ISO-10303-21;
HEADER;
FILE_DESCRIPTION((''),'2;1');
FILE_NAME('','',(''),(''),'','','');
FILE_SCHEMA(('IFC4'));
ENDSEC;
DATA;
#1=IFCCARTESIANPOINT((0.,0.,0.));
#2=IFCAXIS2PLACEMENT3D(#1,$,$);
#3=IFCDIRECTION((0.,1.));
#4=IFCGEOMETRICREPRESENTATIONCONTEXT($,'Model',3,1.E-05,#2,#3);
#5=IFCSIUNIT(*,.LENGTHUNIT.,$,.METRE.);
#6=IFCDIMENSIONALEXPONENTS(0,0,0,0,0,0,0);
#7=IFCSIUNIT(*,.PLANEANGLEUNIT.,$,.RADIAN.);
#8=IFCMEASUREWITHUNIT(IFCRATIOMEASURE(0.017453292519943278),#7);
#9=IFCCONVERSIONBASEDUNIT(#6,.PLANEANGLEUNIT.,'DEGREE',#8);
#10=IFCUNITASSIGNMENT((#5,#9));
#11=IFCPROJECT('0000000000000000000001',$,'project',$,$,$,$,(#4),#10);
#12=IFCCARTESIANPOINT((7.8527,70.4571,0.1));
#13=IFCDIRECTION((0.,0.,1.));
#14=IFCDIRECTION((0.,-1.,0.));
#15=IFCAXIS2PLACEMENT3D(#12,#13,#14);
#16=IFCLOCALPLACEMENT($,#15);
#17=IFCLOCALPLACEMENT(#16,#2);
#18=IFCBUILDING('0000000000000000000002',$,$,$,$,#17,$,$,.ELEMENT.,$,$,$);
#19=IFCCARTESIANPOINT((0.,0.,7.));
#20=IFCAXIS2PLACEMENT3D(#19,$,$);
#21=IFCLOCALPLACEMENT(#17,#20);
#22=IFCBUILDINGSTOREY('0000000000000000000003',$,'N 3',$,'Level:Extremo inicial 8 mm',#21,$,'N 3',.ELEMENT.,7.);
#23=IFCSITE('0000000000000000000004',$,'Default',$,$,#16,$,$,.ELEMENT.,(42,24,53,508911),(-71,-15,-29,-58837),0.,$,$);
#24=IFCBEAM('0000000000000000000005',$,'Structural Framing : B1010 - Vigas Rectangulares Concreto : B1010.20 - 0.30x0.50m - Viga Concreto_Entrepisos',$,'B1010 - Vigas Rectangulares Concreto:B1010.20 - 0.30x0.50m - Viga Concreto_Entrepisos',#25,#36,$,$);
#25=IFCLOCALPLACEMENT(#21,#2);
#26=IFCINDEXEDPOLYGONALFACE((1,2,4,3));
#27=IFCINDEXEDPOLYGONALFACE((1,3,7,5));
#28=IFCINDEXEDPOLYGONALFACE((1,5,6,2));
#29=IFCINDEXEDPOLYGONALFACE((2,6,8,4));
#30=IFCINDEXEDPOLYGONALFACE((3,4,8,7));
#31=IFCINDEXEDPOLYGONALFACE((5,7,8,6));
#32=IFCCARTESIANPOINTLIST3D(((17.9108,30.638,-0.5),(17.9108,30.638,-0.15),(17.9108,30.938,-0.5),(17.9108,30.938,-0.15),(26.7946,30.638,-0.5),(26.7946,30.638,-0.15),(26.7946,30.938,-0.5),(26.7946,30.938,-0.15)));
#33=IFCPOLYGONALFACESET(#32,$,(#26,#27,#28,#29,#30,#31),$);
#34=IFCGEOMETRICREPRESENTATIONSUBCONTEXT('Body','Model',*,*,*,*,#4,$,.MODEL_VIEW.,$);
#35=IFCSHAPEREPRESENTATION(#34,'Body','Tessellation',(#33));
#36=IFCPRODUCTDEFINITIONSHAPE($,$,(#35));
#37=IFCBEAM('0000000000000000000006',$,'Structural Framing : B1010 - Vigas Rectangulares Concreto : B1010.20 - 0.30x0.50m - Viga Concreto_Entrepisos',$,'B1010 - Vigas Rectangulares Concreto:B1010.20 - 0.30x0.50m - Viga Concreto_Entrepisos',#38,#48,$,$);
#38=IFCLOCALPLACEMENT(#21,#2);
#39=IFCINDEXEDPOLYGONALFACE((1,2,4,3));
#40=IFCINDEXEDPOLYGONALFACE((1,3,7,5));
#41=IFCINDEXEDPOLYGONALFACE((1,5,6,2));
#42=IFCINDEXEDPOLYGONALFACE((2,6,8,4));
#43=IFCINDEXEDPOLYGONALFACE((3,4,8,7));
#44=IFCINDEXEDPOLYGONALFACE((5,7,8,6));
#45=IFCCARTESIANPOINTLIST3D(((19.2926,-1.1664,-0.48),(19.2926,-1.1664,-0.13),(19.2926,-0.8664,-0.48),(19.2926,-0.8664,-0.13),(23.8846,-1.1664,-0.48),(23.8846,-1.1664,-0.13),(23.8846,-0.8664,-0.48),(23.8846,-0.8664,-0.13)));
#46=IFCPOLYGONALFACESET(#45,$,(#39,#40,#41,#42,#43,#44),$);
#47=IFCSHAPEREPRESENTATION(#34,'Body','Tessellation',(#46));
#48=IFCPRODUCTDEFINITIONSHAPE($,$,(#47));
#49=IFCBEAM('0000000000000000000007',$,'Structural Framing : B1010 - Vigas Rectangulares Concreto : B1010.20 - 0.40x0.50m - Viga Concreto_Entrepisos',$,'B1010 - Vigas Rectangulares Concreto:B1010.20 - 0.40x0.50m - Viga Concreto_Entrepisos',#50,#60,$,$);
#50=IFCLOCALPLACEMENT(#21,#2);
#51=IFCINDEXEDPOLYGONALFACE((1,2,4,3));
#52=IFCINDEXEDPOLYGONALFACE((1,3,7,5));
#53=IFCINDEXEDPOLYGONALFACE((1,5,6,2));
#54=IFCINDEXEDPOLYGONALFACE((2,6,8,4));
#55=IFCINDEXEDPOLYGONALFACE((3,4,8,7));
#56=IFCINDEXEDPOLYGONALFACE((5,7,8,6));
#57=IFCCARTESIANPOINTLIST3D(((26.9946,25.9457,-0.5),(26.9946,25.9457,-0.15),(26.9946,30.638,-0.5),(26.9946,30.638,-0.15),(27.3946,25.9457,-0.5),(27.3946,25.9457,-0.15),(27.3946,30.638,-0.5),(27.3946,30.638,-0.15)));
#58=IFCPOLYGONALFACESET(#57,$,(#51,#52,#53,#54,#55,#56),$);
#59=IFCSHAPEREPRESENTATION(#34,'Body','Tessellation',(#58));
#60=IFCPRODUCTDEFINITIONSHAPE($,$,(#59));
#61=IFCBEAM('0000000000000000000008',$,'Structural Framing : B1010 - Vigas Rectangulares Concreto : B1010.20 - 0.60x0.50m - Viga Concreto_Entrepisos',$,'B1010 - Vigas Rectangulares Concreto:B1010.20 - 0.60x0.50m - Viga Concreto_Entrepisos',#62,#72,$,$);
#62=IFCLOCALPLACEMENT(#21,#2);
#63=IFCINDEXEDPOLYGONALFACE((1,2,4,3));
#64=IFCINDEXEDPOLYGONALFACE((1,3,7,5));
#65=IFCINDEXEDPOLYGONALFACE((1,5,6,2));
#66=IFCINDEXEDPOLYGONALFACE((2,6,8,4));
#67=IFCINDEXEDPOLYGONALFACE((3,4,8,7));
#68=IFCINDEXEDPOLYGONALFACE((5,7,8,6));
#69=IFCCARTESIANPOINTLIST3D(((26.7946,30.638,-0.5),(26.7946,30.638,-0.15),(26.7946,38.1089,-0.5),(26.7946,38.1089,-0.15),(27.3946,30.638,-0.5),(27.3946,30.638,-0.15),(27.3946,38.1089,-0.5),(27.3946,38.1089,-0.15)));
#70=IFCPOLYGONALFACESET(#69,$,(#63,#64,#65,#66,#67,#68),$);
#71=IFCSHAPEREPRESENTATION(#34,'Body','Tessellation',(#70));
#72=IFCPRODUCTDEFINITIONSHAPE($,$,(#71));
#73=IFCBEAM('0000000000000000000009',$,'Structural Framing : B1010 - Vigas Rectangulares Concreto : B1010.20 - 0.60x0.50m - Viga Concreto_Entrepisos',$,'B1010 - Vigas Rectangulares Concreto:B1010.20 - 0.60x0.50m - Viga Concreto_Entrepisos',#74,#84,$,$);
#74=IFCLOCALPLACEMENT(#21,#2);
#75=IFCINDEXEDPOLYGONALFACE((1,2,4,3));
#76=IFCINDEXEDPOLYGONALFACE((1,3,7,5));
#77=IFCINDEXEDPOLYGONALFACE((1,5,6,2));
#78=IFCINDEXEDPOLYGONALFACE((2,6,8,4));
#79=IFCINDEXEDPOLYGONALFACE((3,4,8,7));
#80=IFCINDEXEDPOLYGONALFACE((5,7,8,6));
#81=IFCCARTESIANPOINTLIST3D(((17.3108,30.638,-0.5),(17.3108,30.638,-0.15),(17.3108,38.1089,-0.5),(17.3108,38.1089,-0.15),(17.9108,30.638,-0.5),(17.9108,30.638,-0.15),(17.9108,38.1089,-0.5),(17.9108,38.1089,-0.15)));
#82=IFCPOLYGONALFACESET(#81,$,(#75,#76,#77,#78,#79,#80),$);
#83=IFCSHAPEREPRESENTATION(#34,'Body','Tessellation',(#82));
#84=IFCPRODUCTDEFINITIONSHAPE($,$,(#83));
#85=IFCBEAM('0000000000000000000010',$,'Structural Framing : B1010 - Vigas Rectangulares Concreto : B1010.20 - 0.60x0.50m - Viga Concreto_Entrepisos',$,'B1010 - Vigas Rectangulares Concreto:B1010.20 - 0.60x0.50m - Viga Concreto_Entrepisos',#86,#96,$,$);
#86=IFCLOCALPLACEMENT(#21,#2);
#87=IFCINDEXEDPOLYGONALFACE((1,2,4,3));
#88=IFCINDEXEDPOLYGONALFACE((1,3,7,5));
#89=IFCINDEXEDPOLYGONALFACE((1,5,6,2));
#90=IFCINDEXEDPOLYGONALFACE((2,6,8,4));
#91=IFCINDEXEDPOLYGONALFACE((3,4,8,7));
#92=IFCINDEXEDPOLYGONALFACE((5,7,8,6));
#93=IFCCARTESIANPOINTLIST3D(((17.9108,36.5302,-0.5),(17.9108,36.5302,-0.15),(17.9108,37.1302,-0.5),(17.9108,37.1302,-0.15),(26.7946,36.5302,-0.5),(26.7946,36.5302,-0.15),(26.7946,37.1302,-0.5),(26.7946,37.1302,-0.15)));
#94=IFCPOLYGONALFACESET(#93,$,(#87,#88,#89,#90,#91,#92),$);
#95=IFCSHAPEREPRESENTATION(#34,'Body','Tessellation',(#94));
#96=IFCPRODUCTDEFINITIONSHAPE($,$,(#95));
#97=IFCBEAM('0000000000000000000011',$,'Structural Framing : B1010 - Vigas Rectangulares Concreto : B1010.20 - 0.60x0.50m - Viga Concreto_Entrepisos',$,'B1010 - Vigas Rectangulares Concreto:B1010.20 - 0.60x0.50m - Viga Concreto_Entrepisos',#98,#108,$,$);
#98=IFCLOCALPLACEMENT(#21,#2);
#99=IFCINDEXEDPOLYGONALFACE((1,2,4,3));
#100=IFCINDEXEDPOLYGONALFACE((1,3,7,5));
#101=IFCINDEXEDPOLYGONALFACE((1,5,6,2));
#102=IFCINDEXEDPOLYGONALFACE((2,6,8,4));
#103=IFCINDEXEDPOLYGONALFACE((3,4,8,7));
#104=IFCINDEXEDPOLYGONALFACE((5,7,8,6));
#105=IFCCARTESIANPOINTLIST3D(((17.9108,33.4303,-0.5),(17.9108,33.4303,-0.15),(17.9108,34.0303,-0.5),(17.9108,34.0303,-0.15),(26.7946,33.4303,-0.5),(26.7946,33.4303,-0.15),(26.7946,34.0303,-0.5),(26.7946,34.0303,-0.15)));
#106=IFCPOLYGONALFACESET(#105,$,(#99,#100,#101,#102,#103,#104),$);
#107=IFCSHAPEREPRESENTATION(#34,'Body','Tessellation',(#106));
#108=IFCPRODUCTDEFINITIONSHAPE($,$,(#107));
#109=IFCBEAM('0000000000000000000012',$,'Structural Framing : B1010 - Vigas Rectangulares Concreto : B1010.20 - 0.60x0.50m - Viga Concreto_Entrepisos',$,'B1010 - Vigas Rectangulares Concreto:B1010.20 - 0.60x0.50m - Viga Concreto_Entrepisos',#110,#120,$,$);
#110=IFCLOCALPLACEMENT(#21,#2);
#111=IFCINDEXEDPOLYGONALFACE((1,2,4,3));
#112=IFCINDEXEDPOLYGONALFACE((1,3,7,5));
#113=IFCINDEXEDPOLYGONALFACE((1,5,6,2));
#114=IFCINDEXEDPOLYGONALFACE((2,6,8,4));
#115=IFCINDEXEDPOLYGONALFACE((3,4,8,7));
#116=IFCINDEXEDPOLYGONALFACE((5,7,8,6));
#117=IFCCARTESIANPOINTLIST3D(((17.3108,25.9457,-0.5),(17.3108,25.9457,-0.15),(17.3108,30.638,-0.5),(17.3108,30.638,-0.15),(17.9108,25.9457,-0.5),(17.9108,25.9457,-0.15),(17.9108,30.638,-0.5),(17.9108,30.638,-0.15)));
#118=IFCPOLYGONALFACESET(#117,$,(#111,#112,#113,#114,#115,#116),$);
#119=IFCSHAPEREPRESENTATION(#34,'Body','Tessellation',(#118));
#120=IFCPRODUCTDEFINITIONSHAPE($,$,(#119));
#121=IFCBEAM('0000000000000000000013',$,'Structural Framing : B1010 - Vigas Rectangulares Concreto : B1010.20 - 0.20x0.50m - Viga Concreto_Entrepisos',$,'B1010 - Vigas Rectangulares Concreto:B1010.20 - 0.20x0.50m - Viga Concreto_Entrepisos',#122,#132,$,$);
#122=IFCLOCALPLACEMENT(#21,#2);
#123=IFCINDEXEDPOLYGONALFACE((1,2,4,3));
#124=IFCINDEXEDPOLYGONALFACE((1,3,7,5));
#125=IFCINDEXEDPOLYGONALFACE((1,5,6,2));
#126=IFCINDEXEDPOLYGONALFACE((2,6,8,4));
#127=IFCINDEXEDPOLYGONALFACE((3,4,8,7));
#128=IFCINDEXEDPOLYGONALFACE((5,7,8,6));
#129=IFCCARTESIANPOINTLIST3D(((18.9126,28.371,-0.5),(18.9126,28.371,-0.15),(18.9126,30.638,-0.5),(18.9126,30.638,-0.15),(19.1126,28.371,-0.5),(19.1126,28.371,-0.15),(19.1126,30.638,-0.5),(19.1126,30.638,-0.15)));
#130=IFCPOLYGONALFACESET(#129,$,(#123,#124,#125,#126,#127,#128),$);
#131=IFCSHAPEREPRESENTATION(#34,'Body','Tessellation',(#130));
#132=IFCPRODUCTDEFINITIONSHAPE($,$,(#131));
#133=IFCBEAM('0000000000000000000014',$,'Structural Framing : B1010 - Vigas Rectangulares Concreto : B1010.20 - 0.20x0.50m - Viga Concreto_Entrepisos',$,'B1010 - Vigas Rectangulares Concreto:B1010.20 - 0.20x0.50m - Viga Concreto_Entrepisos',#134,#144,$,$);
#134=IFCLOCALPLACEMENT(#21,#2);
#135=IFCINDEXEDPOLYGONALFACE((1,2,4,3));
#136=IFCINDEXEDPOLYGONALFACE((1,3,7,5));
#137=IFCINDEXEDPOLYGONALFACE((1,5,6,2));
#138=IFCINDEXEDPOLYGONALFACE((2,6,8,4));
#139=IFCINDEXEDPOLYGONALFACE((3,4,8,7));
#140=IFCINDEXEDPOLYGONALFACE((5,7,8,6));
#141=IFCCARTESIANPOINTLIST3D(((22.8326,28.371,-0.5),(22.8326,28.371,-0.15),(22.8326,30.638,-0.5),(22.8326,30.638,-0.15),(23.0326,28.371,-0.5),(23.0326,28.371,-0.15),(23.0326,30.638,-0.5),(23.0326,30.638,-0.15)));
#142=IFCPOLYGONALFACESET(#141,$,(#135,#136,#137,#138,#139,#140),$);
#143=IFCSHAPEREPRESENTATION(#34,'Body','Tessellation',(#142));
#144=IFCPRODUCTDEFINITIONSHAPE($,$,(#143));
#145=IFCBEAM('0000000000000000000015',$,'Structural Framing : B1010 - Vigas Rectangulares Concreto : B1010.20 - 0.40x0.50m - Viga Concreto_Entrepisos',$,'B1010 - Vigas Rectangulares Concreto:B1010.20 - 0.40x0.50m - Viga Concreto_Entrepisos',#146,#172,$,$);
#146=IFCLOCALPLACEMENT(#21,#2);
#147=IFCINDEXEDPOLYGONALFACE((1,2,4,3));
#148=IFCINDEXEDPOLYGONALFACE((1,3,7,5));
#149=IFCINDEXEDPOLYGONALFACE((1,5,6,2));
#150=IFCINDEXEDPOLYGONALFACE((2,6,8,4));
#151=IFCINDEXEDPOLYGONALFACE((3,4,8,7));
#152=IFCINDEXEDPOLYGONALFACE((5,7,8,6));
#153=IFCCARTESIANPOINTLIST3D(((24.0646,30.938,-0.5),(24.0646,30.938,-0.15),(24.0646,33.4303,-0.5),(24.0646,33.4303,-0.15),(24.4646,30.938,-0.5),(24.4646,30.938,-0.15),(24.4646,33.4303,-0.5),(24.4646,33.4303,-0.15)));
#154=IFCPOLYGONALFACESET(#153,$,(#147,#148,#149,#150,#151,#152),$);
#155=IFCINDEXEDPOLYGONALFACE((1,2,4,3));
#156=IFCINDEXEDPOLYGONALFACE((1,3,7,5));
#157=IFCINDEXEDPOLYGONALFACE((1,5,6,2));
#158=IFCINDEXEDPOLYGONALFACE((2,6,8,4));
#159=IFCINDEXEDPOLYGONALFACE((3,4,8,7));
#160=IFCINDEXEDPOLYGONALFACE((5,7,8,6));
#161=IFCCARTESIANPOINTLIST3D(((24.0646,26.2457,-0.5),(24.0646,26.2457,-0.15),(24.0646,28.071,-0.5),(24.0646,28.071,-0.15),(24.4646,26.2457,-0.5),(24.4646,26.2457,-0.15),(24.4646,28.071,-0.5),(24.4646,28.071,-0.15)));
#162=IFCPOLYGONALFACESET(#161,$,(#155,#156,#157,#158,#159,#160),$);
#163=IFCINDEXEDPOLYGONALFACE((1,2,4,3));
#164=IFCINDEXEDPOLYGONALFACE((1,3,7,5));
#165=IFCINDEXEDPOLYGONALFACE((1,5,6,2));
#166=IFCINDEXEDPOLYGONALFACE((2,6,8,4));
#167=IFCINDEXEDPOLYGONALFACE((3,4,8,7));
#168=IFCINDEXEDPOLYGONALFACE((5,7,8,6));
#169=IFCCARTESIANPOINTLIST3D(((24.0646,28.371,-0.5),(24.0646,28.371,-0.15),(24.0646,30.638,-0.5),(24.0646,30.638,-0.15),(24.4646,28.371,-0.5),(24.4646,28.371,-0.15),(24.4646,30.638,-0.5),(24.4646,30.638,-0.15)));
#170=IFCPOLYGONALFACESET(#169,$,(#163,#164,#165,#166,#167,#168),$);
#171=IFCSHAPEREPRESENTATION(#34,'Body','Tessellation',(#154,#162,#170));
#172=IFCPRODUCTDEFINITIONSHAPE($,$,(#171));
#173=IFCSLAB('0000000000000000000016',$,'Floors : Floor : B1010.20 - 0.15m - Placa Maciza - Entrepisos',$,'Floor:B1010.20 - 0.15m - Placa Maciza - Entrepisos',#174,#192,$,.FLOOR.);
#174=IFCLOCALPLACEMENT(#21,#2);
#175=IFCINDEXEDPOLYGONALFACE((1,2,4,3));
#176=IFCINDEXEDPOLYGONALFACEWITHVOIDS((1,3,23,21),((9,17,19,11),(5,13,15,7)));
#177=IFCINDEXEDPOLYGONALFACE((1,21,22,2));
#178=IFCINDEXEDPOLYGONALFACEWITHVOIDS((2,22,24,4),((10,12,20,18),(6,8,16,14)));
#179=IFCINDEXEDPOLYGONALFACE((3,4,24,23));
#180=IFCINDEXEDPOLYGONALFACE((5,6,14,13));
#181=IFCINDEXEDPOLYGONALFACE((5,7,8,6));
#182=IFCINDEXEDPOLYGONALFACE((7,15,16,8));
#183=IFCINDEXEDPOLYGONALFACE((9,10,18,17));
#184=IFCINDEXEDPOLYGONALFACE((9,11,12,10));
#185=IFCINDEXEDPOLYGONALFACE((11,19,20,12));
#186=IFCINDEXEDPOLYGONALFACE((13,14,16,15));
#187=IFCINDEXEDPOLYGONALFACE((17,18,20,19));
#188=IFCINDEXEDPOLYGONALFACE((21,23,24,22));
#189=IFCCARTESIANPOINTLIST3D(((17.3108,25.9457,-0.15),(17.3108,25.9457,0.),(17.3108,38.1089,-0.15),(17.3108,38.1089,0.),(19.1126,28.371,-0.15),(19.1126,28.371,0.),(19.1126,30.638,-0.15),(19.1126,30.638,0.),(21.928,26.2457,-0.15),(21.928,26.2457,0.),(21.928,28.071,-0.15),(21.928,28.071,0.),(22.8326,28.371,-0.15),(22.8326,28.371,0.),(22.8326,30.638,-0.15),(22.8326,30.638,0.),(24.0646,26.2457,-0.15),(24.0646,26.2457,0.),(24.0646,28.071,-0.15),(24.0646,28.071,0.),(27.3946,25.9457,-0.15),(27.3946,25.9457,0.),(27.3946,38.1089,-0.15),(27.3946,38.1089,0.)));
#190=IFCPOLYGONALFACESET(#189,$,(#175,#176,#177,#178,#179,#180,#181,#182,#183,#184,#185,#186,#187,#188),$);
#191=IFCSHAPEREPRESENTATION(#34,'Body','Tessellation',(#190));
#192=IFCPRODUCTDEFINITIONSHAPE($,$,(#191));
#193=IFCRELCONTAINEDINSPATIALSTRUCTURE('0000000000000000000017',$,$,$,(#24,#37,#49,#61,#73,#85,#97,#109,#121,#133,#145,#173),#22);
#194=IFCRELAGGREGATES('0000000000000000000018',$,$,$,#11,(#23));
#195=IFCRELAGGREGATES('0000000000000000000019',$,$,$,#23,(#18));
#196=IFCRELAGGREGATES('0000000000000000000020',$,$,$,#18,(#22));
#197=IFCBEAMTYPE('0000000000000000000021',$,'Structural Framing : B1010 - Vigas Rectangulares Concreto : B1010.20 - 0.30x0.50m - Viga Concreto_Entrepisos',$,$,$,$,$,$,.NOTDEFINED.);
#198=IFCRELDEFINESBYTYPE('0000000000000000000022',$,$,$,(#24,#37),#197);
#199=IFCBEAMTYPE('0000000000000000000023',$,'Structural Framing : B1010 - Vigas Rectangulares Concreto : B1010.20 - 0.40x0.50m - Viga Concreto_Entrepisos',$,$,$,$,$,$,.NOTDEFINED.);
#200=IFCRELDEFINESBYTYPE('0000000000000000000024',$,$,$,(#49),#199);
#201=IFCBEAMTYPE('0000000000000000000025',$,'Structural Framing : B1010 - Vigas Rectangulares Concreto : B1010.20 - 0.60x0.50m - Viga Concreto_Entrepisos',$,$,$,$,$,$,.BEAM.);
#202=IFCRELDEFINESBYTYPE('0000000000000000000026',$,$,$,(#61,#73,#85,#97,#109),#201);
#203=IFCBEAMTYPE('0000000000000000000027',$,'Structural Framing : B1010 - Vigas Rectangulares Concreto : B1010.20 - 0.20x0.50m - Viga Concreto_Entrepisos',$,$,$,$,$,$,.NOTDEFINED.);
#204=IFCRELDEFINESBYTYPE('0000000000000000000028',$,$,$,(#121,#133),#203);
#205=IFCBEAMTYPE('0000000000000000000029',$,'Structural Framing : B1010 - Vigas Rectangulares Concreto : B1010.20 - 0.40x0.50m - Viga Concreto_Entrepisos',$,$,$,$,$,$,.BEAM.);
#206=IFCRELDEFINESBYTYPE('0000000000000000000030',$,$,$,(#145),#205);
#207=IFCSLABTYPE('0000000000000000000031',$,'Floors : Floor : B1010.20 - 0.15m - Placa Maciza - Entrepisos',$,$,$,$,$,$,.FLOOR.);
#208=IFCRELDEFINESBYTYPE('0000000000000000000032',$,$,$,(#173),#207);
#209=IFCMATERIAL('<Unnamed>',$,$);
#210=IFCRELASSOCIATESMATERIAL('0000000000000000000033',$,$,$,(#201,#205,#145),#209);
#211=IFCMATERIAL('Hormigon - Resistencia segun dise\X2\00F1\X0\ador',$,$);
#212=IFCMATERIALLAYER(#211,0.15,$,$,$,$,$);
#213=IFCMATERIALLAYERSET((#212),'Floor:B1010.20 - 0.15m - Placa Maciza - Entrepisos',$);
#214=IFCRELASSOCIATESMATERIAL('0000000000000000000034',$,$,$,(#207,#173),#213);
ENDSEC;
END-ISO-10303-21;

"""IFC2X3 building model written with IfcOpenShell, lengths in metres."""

from ifc_helpers import new_model, entity, si_unit, converted_unit, direction, frame, frame_2d, origin, origin_2d_with_axis, place, context, subcontext, project, spatial, rectangle, extrude, source, transform, mapped, material, layer, layer_set, layer_usage, type_object, type_shapes, element, save


model = new_model("IFC2X3")

# Units and contexts
model_context = context("Model", 3, precision=1e-05, world=origin(), true_north=direction((0.0, 1.0)))
body_context = subcontext(model_context, "Body", "Model", "MODEL_VIEW")
ifc_project = project(units=[si_unit("LENGTHUNIT", "METRE"), converted_unit("PLANEANGLEUNIT", "DEGREE", entity("IfcRatioMeasure", 0.017453292519943278), si_unit("PLANEANGLEUNIT", "RADIAN"), dimensions=[0, 0, 0, 0, 0, 0, 0])], contexts=[model_context])

# Site, building, storey
site_placement = place(None, frame((7.8527, 70.4571, 0.1), z_axis=(0.0, 0.0, 1.0), x_axis=(0.0, -1.0, 0.0)))
site = spatial("IfcSite", under=ifc_project, at=site_placement, Name="Default", CompositionType="ELEMENT", RefLatitude=(42, 24, 53, 508911), RefLongitude=(-71, -15, -29, -58837), RefElevation=0.0)
building_placement = place(site_placement, origin())
building = spatial("IfcBuilding", under=site, at=building_placement, CompositionType="ELEMENT")
storey_placement = place(building_placement, frame((0.0, 0.0, 7.0)))
storey = spatial("IfcBuildingStorey", under=building, at=storey_placement, Name="N 3", ObjectType="Level:Extremo inicial 8 mm", LongName="N 3", CompositionType="ELEMENT", Elevation=7.0)

# Beams
beam_type_1 = type_object("IfcBeamType", Name="Structural Framing : B1010 - Vigas Rectangulares Concreto : B1010.20 - 0.30x0.50m - Viga Concreto_Entrepisos", PredefinedType="NOTDEFINED")
beam_1_placement = place(storey_placement, frame((17.6108, 30.788, 0.0)))
element("IfcBeam", 1, at=beam_1_placement, inside=storey, type_object=beam_type_1, Name="Structural Framing : B1010 - Vigas Rectangulares Concreto : B1010.20 - 0.30x0.50m - Viga Concreto_Entrepisos", ObjectType="B1010 - Vigas Rectangulares Concreto:B1010.20 - 0.30x0.50m - Viga Concreto_Entrepisos", context=body_context, shape_type="SweptSolid", body=[
    extrude(rectangle(XDim=0.35, YDim=0.3, at=frame_2d((0.0, 0.0), x_axis=(1.0, 0.0))), frame((0.3, 0.0, -0.325), z_axis=(1.0, 0.0, 0.0), x_axis=(0.0, 0.0, -1.0)), (0.0, 0.0, 1.0), 8.8838),
])
beam_2_placement = place(storey_placement, frame((19.1426, -1.0164, 0.0)))
element("IfcBeam", 2, at=beam_2_placement, inside=storey, type_object=beam_type_1, Name="Structural Framing : B1010 - Vigas Rectangulares Concreto : B1010.20 - 0.30x0.50m - Viga Concreto_Entrepisos", ObjectType="B1010 - Vigas Rectangulares Concreto:B1010.20 - 0.30x0.50m - Viga Concreto_Entrepisos", context=body_context, shape_type="SweptSolid", body=[
    extrude(rectangle(XDim=0.35, YDim=0.3, at=frame_2d((0.0, 0.0), x_axis=(1.0, 0.0))), frame((0.15, 0.0, -0.305), z_axis=(1.0, 0.0, 0.0), x_axis=(0.0, 0.0, -1.0)), (0.0, 0.0, 1.0), 4.5921),
])
beam_type_2 = type_object("IfcBeamType", Name="Structural Framing : B1010 - Vigas Rectangulares Concreto : B1010.20 - 0.40x0.50m - Viga Concreto_Entrepisos", PredefinedType="NOTDEFINED")
beam_3_placement = place(storey_placement, frame((27.1946, 26.0957, 0.0), z_axis=(0.0, 0.0, 1.0), x_axis=(0.0, 1.0, 0.0)))
element("IfcBeam", 3, at=beam_3_placement, inside=storey, type_object=beam_type_2, Name="Structural Framing : B1010 - Vigas Rectangulares Concreto : B1010.20 - 0.40x0.50m - Viga Concreto_Entrepisos", ObjectType="B1010 - Vigas Rectangulares Concreto:B1010.20 - 0.40x0.50m - Viga Concreto_Entrepisos", context=body_context, shape_type="SweptSolid", body=[
    extrude(rectangle(XDim=0.35, YDim=0.4, at=frame_2d((0.0, 0.0), x_axis=(1.0, 0.0))), frame((-0.15, 0.0, -0.325), z_axis=(1.0, 0.0, 0.0), x_axis=(0.0, 0.0, -1.0)), (0.0, 0.0, 1.0), 4.6924),
])
ifc_material_1 = material(Name="<Unnamed>")
beam_type_3 = type_object("IfcBeamType", Name="Structural Framing : B1010 - Vigas Rectangulares Concreto : B1010.20 - 0.60x0.50m - Viga Concreto_Entrepisos", PredefinedType="BEAM", material=ifc_material_1)
beam_4_placement = place(storey_placement, frame((27.0946, 30.788, 0.0), z_axis=(0.0, 0.0, 1.0), x_axis=(0.0, 1.0, 0.0)))
element("IfcBeam", 4, at=beam_4_placement, inside=storey, type_object=beam_type_3, Name="Structural Framing : B1010 - Vigas Rectangulares Concreto : B1010.20 - 0.60x0.50m - Viga Concreto_Entrepisos", ObjectType="B1010 - Vigas Rectangulares Concreto:B1010.20 - 0.60x0.50m - Viga Concreto_Entrepisos", context=body_context, shape_type="SweptSolid", body=[
    extrude(rectangle(XDim=0.35, YDim=0.6, at=frame_2d((0.0, 0.0), x_axis=(1.0, 0.0))), frame((-0.15, 0.0, -0.325), z_axis=(1.0, 0.0, 0.0), x_axis=(0.0, 0.0, -1.0)), (0.0, 0.0, 1.0), 7.4709),
])
beam_5_placement = place(storey_placement, frame((17.6108, 30.788, 0.0), z_axis=(0.0, 0.0, 1.0), x_axis=(0.0, 1.0, 0.0)))
element("IfcBeam", 5, at=beam_5_placement, inside=storey, type_object=beam_type_3, Name="Structural Framing : B1010 - Vigas Rectangulares Concreto : B1010.20 - 0.60x0.50m - Viga Concreto_Entrepisos", ObjectType="B1010 - Vigas Rectangulares Concreto:B1010.20 - 0.60x0.50m - Viga Concreto_Entrepisos", context=body_context, shape_type="SweptSolid", body=[
    extrude(rectangle(XDim=0.35, YDim=0.6, at=frame_2d((0.0, 0.0), x_axis=(1.0, 0.0))), frame((-0.15, 0.0, -0.325), z_axis=(1.0, 0.0, 0.0), x_axis=(0.0, 0.0, -1.0)), (0.0, 0.0, 1.0), 7.4709),
])
beam_6_placement = place(storey_placement, frame((17.6108, 36.8302, 0.0)))
element("IfcBeam", 6, at=beam_6_placement, inside=storey, type_object=beam_type_3, Name="Structural Framing : B1010 - Vigas Rectangulares Concreto : B1010.20 - 0.60x0.50m - Viga Concreto_Entrepisos", ObjectType="B1010 - Vigas Rectangulares Concreto:B1010.20 - 0.60x0.50m - Viga Concreto_Entrepisos", context=body_context, shape_type="SweptSolid", body=[
    extrude(rectangle(XDim=0.35, YDim=0.6, at=frame_2d((0.0, 0.0), x_axis=(1.0, 0.0))), frame((0.3, 0.0, -0.325), z_axis=(1.0, 0.0, 0.0), x_axis=(0.0, 0.0, -1.0)), (0.0, 0.0, 1.0), 8.8838),
])
beam_7_placement = place(storey_placement, frame((17.6108, 33.7303, 0.0)))
element("IfcBeam", 7, at=beam_7_placement, inside=storey, type_object=beam_type_3, Name="Structural Framing : B1010 - Vigas Rectangulares Concreto : B1010.20 - 0.60x0.50m - Viga Concreto_Entrepisos", ObjectType="B1010 - Vigas Rectangulares Concreto:B1010.20 - 0.60x0.50m - Viga Concreto_Entrepisos", context=body_context, shape_type="SweptSolid", body=[
    extrude(rectangle(XDim=0.35, YDim=0.6, at=frame_2d((0.0, 0.0), x_axis=(1.0, 0.0))), frame((0.3, 0.0, -0.325), z_axis=(1.0, 0.0, 0.0), x_axis=(0.0, 0.0, -1.0)), (0.0, 0.0, 1.0), 8.8838),
])
beam_8_placement = place(storey_placement, frame((17.6108, 26.0957, 0.0), z_axis=(0.0, 0.0, 1.0), x_axis=(0.0, 1.0, 0.0)))
element("IfcBeam", 8, at=beam_8_placement, inside=storey, type_object=beam_type_3, Name="Structural Framing : B1010 - Vigas Rectangulares Concreto : B1010.20 - 0.60x0.50m - Viga Concreto_Entrepisos", ObjectType="B1010 - Vigas Rectangulares Concreto:B1010.20 - 0.60x0.50m - Viga Concreto_Entrepisos", context=body_context, shape_type="SweptSolid", body=[
    extrude(rectangle(XDim=0.35, YDim=0.6, at=frame_2d((0.0, 0.0), x_axis=(1.0, 0.0))), frame((-0.15, 0.0, -0.325), z_axis=(1.0, 0.0, 0.0), x_axis=(0.0, 0.0, -1.0)), (0.0, 0.0, 1.0), 4.6924),
])
beam_type_4 = type_object("IfcBeamType", Name="Structural Framing : B1010 - Vigas Rectangulares Concreto : B1010.20 - 0.20x0.50m - Viga Concreto_Entrepisos", PredefinedType="NOTDEFINED")
beam_9_placement = place(storey_placement, frame((19.0126, 28.221, 0.0), z_axis=(0.0, 0.0, 1.0), x_axis=(0.0, 1.0, 0.0)))
element("IfcBeam", 9, at=beam_9_placement, inside=storey, type_object=beam_type_4, Name="Structural Framing : B1010 - Vigas Rectangulares Concreto : B1010.20 - 0.20x0.50m - Viga Concreto_Entrepisos", ObjectType="B1010 - Vigas Rectangulares Concreto:B1010.20 - 0.20x0.50m - Viga Concreto_Entrepisos", context=body_context, shape_type="SweptSolid", body=[
    extrude(rectangle(XDim=0.35, YDim=0.2, at=frame_2d((0.0, 0.0), x_axis=(1.0, 0.0))), frame((0.15, 0.0, -0.325), z_axis=(1.0, 0.0, 0.0), x_axis=(0.0, 0.0, -1.0)), (0.0, 0.0, 1.0), 2.2671),
])
beam_10_placement = place(storey_placement, frame((22.9326, 28.171, 0.0), z_axis=(0.0, 0.0, 1.0), x_axis=(0.0, 1.0, 0.0)))
element("IfcBeam", 10, at=beam_10_placement, inside=storey, type_object=beam_type_4, Name="Structural Framing : B1010 - Vigas Rectangulares Concreto : B1010.20 - 0.20x0.50m - Viga Concreto_Entrepisos", ObjectType="B1010 - Vigas Rectangulares Concreto:B1010.20 - 0.20x0.50m - Viga Concreto_Entrepisos", context=body_context, shape_type="SweptSolid", body=[
    extrude(rectangle(XDim=0.35, YDim=0.2, at=origin_2d_with_axis()), frame((0.2, 0.0, -0.325), z_axis=(1.0, 0.0, 0.0), x_axis=(0.0, 0.0, -1.0)), (0.0, 0.0, 1.0), 2.2671),
])
beam_type_5 = type_object("IfcBeamType", Name="Structural Framing : B1010 - Vigas Rectangulares Concreto : B1010.20 - 0.40x0.50m - Viga Concreto_Entrepisos", PredefinedType="BEAM", material=ifc_material_1)
shared_shape = source(origin(), body_context, "Body", "SweptSolid", [
    extrude(rectangle(XDim=0.35, YDim=0.4, at=frame_2d((0.0, 0.0), x_axis=(0.0, 1.0))), frame((24.2646, 30.938, 6.675), z_axis=(0.0, 1.0, 0.0), x_axis=(-1.0, 0.0, 0.0)), (0.0, 0.0, 1.0), 2.4923),
    extrude(rectangle(XDim=0.35, YDim=0.4, at=frame_2d((0.0, 0.0), x_axis=(0.0, 1.0))), frame((24.2646, 26.2457, 6.675), z_axis=(0.0, 1.0, 0.0), x_axis=(-1.0, 0.0, 0.0)), (0.0, 0.0, 1.0), 1.8253),
    extrude(rectangle(XDim=0.35, YDim=0.4, at=frame_2d((0.0, 0.0), x_axis=(0.0, 1.0))), frame((24.2646, 28.371, 6.675), z_axis=(0.0, 1.0, 0.0), x_axis=(-1.0, 0.0, 0.0)), (0.0, 0.0, 1.0), 2.2671),
])
type_shapes(beam_type_5, [shared_shape])
beam_11_placement = place(storey_placement, frame((0.0, 0.0, -7.0)))
element("IfcBeam", 11, at=beam_11_placement, inside=storey, type_object=beam_type_5, material=ifc_material_1, Name="Structural Framing : B1010 - Vigas Rectangulares Concreto : B1010.20 - 0.40x0.50m - Viga Concreto_Entrepisos", ObjectType="B1010 - Vigas Rectangulares Concreto:B1010.20 - 0.40x0.50m - Viga Concreto_Entrepisos", context=body_context, shape_type="MappedRepresentation", body=[
    mapped(shared_shape, transform((0.0, 0.0, 0.0), scale=1.0)),
])

# Slab, openings
ifc_material_2 = material(Name="Hormigon - Resistencia segun diseñador")
ifc_layer_1 = layer(ifc_material_2, 0.15)
ifc_layer_set_1 = layer_set([ifc_layer_1], Name="Floor:B1010.20 - 0.15m - Placa Maciza - Entrepisos")
ifc_layer_usage_1 = layer_usage(ifc_layer_set_1, "AXIS3", "POSITIVE", 0.0)
slab_type_1 = type_object("IfcSlabType", Name="Floors : Floor : B1010.20 - 0.15m - Placa Maciza - Entrepisos", PredefinedType="FLOOR", material=ifc_layer_set_1)
slab_1_placement = place(storey_placement, frame((17.3108, 25.9457, -0.15)))
slab_1 = element("IfcSlab", 12, at=slab_1_placement, inside=storey, type_object=slab_type_1, material=ifc_layer_usage_1, Name="Floors : Floor : B1010.20 - 0.15m - Placa Maciza - Entrepisos", ObjectType="Floor:B1010.20 - 0.15m - Placa Maciza - Entrepisos", PredefinedType="FLOOR", context=body_context, shape_type="SweptSolid", body=[
    extrude(rectangle(XDim=12.1632, YDim=10.0838, at=frame_2d((0.0, 0.0), x_axis=(0.0, 1.0))), frame((5.0419, 6.0816, 0.15), z_axis=(0.0, 0.0, -1.0), x_axis=(-1.0, 0.0, 0.0)), (0.0, 0.0, 1.0), 0.15),
])
opening_1_placement = place(slab_1_placement, frame((3.6617, 3.5588, 0.15)))
element("IfcOpeningElement", 13, at=opening_1_placement, cuts=slab_1, ObjectType="Opening", context=body_context, shape_type="SweptSolid", body=[
    extrude(rectangle(XDim=2.2671, YDim=3.72, at=origin_2d_with_axis()), frame((0.0, 0.0, 0.0), z_axis=(0.0, 0.0, 1.0), x_axis=(0.0, -1.0, 0.0)), (0.0, 0.0, -1.0), 0.15),
])
opening_2_placement = place(slab_1_placement, frame((5.6855, 1.2126, 0.15)))
element("IfcOpeningElement", 14, at=opening_2_placement, cuts=slab_1, ObjectType="Opening", context=body_context, shape_type="SweptSolid", body=[
    extrude(rectangle(XDim=1.8253, YDim=2.1366, at=origin_2d_with_axis()), frame((0.0, 0.0, 0.0), z_axis=(0.0, 0.0, -1.0), x_axis=(0.0, -1.0, 0.0)), (0.0, 0.0, 1.0), 0.15),
])

save(model, "model.ifc")
